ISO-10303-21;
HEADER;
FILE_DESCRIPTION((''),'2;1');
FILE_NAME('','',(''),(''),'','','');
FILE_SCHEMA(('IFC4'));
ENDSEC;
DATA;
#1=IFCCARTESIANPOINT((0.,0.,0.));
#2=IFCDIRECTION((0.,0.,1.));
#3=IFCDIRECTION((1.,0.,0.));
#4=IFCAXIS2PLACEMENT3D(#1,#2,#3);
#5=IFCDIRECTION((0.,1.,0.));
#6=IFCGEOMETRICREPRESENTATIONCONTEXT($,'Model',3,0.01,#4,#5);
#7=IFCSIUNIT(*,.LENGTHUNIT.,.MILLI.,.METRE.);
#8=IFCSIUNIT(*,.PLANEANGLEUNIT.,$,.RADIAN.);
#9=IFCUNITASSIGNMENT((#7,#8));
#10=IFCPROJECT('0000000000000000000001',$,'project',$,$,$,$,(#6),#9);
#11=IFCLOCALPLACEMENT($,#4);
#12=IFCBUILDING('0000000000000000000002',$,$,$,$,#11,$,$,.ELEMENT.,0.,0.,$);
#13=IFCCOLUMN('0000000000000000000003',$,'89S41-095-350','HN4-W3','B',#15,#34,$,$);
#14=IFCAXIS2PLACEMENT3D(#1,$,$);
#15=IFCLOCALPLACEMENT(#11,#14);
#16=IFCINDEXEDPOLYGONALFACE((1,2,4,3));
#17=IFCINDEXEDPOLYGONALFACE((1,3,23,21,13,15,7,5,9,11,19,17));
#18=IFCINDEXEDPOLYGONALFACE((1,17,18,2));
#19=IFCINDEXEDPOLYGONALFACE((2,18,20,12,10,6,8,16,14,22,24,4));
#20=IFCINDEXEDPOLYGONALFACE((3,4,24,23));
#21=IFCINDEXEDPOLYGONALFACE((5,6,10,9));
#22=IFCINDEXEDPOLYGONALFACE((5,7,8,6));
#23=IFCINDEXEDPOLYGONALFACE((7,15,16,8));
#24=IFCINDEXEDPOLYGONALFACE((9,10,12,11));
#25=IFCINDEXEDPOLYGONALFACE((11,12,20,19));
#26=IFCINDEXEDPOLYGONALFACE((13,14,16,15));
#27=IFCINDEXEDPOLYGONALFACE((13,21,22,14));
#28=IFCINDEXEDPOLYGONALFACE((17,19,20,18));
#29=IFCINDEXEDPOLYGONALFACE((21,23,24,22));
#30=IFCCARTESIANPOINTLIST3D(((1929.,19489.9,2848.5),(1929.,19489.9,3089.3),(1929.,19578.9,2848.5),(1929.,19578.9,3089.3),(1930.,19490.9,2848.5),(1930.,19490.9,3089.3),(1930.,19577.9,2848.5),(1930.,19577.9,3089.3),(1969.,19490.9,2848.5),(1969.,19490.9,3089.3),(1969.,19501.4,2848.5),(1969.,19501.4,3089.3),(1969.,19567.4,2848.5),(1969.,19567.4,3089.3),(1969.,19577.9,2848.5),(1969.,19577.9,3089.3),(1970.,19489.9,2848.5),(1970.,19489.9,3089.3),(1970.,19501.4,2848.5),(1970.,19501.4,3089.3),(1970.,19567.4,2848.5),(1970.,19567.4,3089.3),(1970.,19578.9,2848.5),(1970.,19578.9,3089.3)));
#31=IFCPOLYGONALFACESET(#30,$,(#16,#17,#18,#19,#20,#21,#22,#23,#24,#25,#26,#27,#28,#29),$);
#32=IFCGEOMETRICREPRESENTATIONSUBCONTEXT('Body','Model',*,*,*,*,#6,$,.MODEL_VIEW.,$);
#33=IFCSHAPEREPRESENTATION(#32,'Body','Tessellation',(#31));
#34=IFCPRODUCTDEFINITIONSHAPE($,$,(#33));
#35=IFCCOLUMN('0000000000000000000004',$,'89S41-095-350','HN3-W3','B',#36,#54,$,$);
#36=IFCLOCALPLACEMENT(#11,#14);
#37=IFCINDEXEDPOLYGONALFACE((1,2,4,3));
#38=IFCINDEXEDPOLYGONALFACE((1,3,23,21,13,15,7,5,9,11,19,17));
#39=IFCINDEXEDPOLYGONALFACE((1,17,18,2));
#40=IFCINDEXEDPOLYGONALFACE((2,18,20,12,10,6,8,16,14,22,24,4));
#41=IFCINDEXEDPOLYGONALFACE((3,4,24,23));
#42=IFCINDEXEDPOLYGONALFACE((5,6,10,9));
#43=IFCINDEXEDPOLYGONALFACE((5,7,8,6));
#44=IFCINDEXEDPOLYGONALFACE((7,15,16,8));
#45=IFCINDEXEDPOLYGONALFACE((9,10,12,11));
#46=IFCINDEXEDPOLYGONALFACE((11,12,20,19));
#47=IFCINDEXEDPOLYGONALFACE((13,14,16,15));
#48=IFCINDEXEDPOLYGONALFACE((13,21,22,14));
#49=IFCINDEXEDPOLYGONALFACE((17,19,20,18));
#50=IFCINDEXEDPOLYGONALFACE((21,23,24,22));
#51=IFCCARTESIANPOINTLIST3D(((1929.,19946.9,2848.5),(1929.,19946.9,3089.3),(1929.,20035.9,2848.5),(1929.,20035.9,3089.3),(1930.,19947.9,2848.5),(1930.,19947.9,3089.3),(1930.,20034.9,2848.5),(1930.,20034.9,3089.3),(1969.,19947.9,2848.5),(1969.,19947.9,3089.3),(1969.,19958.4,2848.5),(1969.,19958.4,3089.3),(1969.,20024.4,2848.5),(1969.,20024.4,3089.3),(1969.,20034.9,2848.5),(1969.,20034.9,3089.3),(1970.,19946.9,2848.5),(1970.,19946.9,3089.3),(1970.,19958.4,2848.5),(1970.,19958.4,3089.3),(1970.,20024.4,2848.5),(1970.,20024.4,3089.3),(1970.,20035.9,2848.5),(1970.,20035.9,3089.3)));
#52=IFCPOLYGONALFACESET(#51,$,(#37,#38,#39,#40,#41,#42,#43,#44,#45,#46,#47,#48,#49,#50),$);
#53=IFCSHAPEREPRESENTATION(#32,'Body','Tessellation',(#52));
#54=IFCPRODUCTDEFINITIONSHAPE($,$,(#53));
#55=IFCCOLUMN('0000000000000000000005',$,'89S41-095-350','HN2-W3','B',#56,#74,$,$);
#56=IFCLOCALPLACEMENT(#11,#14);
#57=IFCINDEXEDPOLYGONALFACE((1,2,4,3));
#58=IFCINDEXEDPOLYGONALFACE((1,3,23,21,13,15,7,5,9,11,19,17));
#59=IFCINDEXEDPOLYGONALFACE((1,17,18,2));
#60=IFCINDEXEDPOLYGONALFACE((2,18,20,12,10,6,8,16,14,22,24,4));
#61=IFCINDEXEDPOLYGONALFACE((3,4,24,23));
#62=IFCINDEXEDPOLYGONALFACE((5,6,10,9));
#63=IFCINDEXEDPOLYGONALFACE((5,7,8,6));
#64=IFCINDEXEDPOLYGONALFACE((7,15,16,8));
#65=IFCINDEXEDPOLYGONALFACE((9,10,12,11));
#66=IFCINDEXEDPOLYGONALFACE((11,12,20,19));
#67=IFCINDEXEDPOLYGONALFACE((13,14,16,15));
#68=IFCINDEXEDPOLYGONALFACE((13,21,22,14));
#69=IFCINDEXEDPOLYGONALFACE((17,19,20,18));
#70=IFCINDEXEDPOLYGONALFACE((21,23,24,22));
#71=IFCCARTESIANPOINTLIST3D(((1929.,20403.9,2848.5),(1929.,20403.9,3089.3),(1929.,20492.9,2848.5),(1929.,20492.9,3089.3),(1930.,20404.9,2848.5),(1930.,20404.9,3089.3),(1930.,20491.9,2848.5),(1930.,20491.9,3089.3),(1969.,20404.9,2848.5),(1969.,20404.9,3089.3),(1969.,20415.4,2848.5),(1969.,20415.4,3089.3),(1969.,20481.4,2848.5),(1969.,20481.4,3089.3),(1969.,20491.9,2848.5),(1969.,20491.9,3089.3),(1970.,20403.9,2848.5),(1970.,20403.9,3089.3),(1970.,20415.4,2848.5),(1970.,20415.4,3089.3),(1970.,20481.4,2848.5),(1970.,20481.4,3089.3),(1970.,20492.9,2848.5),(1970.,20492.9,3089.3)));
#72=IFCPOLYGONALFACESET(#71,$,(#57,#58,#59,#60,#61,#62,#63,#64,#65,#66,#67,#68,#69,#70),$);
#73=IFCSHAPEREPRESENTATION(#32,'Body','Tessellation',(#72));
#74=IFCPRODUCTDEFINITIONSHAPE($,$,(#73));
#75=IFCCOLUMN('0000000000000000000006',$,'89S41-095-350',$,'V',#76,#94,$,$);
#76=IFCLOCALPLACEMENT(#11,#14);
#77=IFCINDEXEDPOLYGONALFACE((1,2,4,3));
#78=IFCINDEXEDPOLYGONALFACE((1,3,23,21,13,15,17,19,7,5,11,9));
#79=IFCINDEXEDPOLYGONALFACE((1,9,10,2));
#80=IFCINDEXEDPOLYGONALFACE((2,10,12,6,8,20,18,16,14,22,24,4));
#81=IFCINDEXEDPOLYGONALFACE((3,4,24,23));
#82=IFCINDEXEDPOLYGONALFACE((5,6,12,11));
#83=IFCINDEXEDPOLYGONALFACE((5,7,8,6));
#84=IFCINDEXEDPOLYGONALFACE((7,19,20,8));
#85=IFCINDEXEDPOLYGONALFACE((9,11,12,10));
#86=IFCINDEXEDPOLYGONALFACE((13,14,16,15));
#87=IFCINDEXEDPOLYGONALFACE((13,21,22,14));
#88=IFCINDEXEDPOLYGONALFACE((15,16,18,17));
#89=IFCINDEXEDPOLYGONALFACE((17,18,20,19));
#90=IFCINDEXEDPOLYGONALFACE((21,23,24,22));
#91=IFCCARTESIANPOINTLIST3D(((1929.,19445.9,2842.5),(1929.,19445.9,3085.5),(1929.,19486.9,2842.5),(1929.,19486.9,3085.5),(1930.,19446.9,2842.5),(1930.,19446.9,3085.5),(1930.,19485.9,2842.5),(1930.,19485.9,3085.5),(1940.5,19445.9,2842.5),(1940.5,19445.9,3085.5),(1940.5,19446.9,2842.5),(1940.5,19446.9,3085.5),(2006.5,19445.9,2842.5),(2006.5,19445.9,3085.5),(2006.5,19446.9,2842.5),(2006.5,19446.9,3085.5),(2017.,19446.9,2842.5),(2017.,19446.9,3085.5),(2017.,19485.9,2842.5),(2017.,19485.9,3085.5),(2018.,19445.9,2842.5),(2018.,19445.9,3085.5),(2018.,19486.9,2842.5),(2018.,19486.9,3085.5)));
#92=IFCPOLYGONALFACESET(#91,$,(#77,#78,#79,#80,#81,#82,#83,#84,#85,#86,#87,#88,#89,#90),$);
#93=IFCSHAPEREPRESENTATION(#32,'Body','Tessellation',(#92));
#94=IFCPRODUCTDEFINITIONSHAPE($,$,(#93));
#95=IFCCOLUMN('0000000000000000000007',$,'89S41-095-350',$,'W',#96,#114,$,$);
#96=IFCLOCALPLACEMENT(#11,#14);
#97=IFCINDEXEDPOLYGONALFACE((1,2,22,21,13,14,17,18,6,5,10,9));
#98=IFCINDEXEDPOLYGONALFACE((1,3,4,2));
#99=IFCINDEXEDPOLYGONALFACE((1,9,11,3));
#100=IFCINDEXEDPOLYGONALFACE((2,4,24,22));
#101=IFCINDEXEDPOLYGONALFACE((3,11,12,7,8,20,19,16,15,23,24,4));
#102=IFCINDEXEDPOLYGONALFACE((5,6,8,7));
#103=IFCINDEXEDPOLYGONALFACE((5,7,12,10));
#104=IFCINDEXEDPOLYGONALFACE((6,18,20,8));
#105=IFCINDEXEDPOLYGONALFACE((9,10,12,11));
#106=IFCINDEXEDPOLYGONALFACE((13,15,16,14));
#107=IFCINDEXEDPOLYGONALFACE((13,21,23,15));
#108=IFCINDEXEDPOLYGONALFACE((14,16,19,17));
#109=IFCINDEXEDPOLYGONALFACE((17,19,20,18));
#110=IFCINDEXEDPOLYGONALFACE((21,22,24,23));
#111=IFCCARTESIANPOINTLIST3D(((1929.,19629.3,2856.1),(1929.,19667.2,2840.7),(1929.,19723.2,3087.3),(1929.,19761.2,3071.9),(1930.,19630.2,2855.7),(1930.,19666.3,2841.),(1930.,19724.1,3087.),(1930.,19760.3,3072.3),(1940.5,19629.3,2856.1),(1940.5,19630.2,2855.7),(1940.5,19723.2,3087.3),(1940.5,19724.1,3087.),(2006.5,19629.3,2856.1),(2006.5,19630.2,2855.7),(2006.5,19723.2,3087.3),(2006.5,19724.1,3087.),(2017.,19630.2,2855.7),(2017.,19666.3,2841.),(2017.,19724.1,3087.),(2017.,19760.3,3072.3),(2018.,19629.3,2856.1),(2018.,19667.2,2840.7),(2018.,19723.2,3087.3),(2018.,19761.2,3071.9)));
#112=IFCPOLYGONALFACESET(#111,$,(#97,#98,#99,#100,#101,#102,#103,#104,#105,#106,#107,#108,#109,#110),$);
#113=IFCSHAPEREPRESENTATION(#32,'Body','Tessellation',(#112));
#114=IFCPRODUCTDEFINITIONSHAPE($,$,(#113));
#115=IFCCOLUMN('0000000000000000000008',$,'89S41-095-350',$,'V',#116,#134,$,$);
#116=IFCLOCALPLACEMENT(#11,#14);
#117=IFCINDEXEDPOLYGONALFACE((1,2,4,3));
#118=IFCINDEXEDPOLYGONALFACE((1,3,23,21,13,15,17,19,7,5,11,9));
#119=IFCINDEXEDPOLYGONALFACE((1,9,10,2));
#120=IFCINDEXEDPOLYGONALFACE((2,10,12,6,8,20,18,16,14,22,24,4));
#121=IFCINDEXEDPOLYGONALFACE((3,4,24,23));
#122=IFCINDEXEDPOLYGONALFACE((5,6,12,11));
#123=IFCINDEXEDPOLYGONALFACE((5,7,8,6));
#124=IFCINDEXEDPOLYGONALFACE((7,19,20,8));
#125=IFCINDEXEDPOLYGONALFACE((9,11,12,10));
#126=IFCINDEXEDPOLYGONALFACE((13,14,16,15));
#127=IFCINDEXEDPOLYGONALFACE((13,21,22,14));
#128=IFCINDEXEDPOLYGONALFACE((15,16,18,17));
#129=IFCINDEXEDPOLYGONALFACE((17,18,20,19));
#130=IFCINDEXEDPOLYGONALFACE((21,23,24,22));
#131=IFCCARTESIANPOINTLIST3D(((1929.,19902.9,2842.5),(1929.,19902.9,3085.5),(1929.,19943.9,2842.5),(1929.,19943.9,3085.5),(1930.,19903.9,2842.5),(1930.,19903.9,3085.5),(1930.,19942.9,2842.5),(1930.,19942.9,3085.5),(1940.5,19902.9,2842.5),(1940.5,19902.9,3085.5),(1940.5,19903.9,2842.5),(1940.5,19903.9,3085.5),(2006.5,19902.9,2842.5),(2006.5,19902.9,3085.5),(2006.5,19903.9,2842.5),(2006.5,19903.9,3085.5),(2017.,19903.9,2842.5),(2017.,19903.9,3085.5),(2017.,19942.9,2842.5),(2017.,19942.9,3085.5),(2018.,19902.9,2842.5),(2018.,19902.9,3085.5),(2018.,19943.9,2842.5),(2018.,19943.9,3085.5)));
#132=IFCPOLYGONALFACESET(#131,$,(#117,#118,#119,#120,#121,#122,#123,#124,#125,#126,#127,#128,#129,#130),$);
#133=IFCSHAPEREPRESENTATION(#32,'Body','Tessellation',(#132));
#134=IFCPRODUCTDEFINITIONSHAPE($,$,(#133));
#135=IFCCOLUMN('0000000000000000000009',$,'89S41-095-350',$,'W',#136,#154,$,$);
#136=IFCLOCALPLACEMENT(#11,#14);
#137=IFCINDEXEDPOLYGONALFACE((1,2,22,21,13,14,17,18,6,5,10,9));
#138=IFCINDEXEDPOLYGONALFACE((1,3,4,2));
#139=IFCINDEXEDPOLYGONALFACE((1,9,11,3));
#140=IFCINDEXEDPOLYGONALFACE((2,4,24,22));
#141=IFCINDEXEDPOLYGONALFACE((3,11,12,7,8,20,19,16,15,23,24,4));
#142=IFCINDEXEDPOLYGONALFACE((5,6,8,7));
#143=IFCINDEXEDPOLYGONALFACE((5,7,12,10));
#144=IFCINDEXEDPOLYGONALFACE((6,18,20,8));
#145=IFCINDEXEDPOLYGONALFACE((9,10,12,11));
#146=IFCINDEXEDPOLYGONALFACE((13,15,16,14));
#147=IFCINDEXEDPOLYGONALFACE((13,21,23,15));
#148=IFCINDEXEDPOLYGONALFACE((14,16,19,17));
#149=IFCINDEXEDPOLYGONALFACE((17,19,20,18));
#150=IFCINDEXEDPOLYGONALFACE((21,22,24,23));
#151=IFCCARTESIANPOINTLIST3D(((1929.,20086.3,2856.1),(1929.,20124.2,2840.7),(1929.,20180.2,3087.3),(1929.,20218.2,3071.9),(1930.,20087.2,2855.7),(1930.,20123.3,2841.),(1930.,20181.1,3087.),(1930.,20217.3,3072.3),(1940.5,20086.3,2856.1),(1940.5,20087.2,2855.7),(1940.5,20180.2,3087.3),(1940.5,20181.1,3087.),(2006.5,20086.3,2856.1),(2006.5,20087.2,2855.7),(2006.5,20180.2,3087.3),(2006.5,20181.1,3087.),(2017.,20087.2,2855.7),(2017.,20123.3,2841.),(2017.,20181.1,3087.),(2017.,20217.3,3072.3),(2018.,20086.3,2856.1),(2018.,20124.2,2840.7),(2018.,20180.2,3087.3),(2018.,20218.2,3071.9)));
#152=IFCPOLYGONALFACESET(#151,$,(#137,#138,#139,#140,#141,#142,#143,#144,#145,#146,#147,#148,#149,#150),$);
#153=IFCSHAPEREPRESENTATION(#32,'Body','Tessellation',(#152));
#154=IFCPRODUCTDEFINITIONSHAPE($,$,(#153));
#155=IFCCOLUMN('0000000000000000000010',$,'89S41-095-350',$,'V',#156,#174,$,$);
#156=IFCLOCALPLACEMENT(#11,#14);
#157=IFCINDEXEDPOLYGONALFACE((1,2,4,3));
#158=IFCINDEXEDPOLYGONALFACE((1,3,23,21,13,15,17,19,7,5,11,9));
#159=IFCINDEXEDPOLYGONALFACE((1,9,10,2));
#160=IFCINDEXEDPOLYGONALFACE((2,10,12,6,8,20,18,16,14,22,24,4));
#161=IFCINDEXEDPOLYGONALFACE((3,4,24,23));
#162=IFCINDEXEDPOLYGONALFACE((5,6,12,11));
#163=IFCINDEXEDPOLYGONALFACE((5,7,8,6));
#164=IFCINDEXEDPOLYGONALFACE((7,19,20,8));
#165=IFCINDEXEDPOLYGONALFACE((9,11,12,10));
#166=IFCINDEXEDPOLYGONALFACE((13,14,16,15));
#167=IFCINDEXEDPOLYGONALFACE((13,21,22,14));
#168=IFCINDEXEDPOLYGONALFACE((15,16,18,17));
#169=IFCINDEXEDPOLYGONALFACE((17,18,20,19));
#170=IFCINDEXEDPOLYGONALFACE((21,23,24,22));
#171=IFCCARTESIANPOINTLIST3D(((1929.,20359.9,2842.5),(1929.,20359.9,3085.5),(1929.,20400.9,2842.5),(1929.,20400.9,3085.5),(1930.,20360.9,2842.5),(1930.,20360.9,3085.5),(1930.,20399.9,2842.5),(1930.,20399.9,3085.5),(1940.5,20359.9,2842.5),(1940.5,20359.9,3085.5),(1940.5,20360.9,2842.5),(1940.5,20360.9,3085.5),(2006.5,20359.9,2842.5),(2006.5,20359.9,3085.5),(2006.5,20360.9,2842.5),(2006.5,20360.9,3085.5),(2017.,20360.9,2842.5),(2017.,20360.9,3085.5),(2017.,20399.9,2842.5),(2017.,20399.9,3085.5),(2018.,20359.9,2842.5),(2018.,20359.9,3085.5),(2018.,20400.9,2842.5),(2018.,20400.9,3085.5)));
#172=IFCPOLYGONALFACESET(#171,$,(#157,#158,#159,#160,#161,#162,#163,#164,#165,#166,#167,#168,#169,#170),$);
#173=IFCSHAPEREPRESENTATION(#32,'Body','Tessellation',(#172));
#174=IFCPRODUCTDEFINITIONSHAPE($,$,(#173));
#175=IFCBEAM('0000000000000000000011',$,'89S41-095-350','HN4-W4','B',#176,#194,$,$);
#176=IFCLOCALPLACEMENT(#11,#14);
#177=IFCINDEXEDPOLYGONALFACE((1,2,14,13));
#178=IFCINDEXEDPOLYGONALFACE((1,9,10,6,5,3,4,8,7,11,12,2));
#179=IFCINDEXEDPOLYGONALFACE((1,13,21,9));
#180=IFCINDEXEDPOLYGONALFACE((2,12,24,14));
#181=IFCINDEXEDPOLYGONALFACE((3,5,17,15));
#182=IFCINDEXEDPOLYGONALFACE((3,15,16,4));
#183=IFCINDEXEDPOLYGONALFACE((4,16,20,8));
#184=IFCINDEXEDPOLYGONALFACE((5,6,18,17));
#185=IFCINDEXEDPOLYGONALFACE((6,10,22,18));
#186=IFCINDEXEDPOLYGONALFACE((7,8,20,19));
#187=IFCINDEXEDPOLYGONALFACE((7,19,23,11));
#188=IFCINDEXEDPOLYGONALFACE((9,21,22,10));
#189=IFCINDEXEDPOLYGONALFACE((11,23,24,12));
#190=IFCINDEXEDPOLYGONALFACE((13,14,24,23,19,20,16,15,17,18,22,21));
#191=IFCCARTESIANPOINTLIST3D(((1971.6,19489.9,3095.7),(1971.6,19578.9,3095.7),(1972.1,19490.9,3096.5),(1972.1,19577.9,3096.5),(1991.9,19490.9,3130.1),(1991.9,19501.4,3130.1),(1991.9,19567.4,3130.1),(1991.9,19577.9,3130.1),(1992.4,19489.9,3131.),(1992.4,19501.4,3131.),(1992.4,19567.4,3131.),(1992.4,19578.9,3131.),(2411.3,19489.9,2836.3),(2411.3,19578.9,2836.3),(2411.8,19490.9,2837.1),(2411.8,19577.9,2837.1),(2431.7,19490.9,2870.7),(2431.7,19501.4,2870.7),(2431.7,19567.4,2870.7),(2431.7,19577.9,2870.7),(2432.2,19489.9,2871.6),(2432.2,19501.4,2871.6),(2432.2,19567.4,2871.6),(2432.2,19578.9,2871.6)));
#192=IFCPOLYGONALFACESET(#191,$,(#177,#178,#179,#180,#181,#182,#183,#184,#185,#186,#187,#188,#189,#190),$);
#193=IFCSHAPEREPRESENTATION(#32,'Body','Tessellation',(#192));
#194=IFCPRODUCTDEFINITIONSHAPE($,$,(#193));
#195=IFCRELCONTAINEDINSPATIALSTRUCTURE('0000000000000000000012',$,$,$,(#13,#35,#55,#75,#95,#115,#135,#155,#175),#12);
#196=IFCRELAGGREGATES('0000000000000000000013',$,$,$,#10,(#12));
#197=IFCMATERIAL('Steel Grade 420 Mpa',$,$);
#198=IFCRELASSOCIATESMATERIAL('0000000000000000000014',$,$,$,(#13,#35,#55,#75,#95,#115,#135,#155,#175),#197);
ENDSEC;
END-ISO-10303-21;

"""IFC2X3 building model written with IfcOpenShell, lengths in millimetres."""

from ifc_helpers import new_model, si_unit, direction, frame, origin, origin_with_axes, origin_2d_with_axis, place, context, subcontext, project, spatial, c_section, extrude, source, transform, mapped, material, element, save


model = new_model("IFC2X3")

# Units and contexts
model_context = context("Model", 3, precision=0.01, world=origin_with_axes(), true_north=direction((0.0, 1.0, 0.0)))
body_context = subcontext(model_context, "Body", "Model", "MODEL_VIEW")
ifc_project = project(units=[si_unit("LENGTHUNIT", "METRE", prefix="MILLI"), si_unit("PLANEANGLEUNIT", "RADIAN")], contexts=[model_context])

# Building
building_placement = place(None, origin_with_axes())
building = spatial("IfcBuilding", under=ifc_project, at=building_placement, CompositionType="ELEMENT", ElevationOfRefHeight=0.0, ElevationOfTerrain=0.0)

# Columns
ifc_material = material(Name="Steel Grade 420 Mpa")
shared_shape_1 = source(origin(), body_context, "Body", "SweptSolid", [
    extrude(c_section(Depth=89.0, Width=41.0, WallThickness=1.0, Girth=11.5, at=origin_2d_with_axis()), origin_with_axes(), (0.0, 0.0, 1.0), 240.8),
])
column_1_placement = place(None, frame((1949.5, 19534.4, 3089.3), z_axis=(0.0, 0.0, -1.0), x_axis=(1.0, 0.0, 0.0)))
element("IfcColumn", 1, at=column_1_placement, inside=building, material=ifc_material, Name="89S41-095-350", Description="HN4-W3", ObjectType="B", context=body_context, shape_type="MappedRepresentation", body=[
    mapped(shared_shape_1, transform((0.0, 0.0, 0.0), scale=1.0)),
])
shared_shape_2 = source(origin(), body_context, "Body", "SweptSolid", [
    extrude(c_section(Depth=89.0, Width=41.0, WallThickness=1.0, Girth=11.5, at=origin_2d_with_axis()), origin_with_axes(), (0.0, 0.0, 1.0), 240.8),
])
column_2_placement = place(None, frame((1949.5, 19991.4, 3089.3), z_axis=(0.0, 0.0, -1.0), x_axis=(1.0, 0.0, 0.0)))
element("IfcColumn", 2, at=column_2_placement, inside=building, material=ifc_material, Name="89S41-095-350", Description="HN3-W3", ObjectType="B", context=body_context, shape_type="MappedRepresentation", body=[
    mapped(shared_shape_2, transform((0.0, 0.0, 0.0), scale=1.0)),
])
shared_shape_3 = source(origin(), body_context, "Body", "SweptSolid", [
    extrude(c_section(Depth=89.0, Width=41.0, WallThickness=1.0, Girth=11.5, at=origin_2d_with_axis()), origin_with_axes(), (0.0, 0.0, 1.0), 240.8),
])
column_3_placement = place(None, frame((1949.5, 20448.4, 3089.3), z_axis=(0.0, 0.0, -1.0), x_axis=(1.0, 0.0, 0.0)))
element("IfcColumn", 3, at=column_3_placement, inside=building, material=ifc_material, Name="89S41-095-350", Description="HN2-W3", ObjectType="B", context=body_context, shape_type="MappedRepresentation", body=[
    mapped(shared_shape_3, transform((0.0, 0.0, 0.0), scale=1.0)),
])
shared_shape_4 = source(origin(), body_context, "Body", "SweptSolid", [
    extrude(c_section(Depth=89.0, Width=41.0, WallThickness=1.0, Girth=11.5, at=origin_2d_with_axis()), origin_with_axes(), (0.0, 0.0, 1.0), 243.0),
])
column_4_placement = place(None, frame((1973.5, 19466.4, 3085.5), z_axis=(0.0, 0.0, -1.0), x_axis=(0.0, -1.0, 0.0)))
element("IfcColumn", 4, at=column_4_placement, inside=building, material=ifc_material, Name="89S41-095-350", ObjectType="V", context=body_context, shape_type="MappedRepresentation", body=[
    mapped(shared_shape_4, transform((0.0, 0.0, 0.0), scale=1.0)),
])
shared_shape_5 = source(origin(), body_context, "Body", "SweptSolid", [
    extrude(c_section(Depth=89.0, Width=41.0, WallThickness=1.0, Girth=11.5, at=origin_2d_with_axis()), origin_with_axes(), (0.0, 0.0, 1.0), 249.6),
])
column_5_placement = place(None, frame((1973.5, 19742.2, 3079.6), z_axis=(0.0, -0.376416, -0.926451), x_axis=(0.0, -0.926451, 0.376416)))
element("IfcColumn", 5, at=column_5_placement, inside=building, material=ifc_material, Name="89S41-095-350", ObjectType="W", context=body_context, shape_type="MappedRepresentation", body=[
    mapped(shared_shape_5, transform((0.0, 0.0, 0.0), scale=1.0)),
])
shared_shape_6 = source(origin(), body_context, "Body", "SweptSolid", [
    extrude(c_section(Depth=89.0, Width=41.0, WallThickness=1.0, Girth=11.5, at=origin_2d_with_axis()), origin_with_axes(), (0.0, 0.0, 1.0), 243.0),
])
column_6_placement = place(None, frame((1973.5, 19923.4, 3085.5), z_axis=(0.0, 0.0, -1.0), x_axis=(0.0, -1.0, 0.0)))
element("IfcColumn", 6, at=column_6_placement, inside=building, material=ifc_material, Name="89S41-095-350", ObjectType="V", context=body_context, shape_type="MappedRepresentation", body=[
    mapped(shared_shape_6, transform((0.0, 0.0, 0.0), scale=1.0)),
])
shared_shape_7 = source(origin(), body_context, "Body", "SweptSolid", [
    extrude(c_section(Depth=89.0, Width=41.0, WallThickness=1.0, Girth=11.5, at=origin_2d_with_axis()), origin_with_axes(), (0.0, 0.0, 1.0), 249.6),
])
column_7_placement = place(None, frame((1973.5, 20199.2, 3079.6), z_axis=(0.0, -0.376416, -0.926451), x_axis=(0.0, -0.926451, 0.376416)))
element("IfcColumn", 7, at=column_7_placement, inside=building, material=ifc_material, Name="89S41-095-350", ObjectType="W", context=body_context, shape_type="MappedRepresentation", body=[
    mapped(shared_shape_7, transform((0.0, 0.0, 0.0), scale=1.0)),
])
shared_shape_8 = source(origin(), body_context, "Body", "SweptSolid", [
    extrude(c_section(Depth=89.0, Width=41.0, WallThickness=1.0, Girth=11.5, at=origin_2d_with_axis()), origin_with_axes(), (0.0, 0.0, 1.0), 243.0),
])
column_8_placement = place(None, frame((1973.5, 20380.4, 3085.5), z_axis=(0.0, 0.0, -1.0), x_axis=(0.0, -1.0, 0.0)))
element("IfcColumn", 8, at=column_8_placement, inside=building, material=ifc_material, Name="89S41-095-350", ObjectType="V", context=body_context, shape_type="MappedRepresentation", body=[
    mapped(shared_shape_8, transform((0.0, 0.0, 0.0), scale=1.0)),
])

# Beam
shared_shape_9 = source(origin(), body_context, "Body", "SweptSolid", [
    extrude(c_section(Depth=89.0, Width=41.0, WallThickness=1.0, Girth=11.5, at=origin_2d_with_axis()), origin_with_axes(), (0.0, 0.0, 1.0), 510.5),
])
beam_1_placement = place(None, frame((1982.0, 19534.4, 3113.3), z_axis=(0.861295, 0.0, -0.508104), x_axis=(0.508104, 0.0, 0.861295)))
element("IfcBeam", 9, at=beam_1_placement, inside=building, material=ifc_material, Name="89S41-095-350", Description="HN4-W4", ObjectType="B", context=body_context, shape_type="MappedRepresentation", body=[
    mapped(shared_shape_9, transform((0.0, 0.0, 0.0), scale=1.0)),
])

save(model, "model.ifc")
